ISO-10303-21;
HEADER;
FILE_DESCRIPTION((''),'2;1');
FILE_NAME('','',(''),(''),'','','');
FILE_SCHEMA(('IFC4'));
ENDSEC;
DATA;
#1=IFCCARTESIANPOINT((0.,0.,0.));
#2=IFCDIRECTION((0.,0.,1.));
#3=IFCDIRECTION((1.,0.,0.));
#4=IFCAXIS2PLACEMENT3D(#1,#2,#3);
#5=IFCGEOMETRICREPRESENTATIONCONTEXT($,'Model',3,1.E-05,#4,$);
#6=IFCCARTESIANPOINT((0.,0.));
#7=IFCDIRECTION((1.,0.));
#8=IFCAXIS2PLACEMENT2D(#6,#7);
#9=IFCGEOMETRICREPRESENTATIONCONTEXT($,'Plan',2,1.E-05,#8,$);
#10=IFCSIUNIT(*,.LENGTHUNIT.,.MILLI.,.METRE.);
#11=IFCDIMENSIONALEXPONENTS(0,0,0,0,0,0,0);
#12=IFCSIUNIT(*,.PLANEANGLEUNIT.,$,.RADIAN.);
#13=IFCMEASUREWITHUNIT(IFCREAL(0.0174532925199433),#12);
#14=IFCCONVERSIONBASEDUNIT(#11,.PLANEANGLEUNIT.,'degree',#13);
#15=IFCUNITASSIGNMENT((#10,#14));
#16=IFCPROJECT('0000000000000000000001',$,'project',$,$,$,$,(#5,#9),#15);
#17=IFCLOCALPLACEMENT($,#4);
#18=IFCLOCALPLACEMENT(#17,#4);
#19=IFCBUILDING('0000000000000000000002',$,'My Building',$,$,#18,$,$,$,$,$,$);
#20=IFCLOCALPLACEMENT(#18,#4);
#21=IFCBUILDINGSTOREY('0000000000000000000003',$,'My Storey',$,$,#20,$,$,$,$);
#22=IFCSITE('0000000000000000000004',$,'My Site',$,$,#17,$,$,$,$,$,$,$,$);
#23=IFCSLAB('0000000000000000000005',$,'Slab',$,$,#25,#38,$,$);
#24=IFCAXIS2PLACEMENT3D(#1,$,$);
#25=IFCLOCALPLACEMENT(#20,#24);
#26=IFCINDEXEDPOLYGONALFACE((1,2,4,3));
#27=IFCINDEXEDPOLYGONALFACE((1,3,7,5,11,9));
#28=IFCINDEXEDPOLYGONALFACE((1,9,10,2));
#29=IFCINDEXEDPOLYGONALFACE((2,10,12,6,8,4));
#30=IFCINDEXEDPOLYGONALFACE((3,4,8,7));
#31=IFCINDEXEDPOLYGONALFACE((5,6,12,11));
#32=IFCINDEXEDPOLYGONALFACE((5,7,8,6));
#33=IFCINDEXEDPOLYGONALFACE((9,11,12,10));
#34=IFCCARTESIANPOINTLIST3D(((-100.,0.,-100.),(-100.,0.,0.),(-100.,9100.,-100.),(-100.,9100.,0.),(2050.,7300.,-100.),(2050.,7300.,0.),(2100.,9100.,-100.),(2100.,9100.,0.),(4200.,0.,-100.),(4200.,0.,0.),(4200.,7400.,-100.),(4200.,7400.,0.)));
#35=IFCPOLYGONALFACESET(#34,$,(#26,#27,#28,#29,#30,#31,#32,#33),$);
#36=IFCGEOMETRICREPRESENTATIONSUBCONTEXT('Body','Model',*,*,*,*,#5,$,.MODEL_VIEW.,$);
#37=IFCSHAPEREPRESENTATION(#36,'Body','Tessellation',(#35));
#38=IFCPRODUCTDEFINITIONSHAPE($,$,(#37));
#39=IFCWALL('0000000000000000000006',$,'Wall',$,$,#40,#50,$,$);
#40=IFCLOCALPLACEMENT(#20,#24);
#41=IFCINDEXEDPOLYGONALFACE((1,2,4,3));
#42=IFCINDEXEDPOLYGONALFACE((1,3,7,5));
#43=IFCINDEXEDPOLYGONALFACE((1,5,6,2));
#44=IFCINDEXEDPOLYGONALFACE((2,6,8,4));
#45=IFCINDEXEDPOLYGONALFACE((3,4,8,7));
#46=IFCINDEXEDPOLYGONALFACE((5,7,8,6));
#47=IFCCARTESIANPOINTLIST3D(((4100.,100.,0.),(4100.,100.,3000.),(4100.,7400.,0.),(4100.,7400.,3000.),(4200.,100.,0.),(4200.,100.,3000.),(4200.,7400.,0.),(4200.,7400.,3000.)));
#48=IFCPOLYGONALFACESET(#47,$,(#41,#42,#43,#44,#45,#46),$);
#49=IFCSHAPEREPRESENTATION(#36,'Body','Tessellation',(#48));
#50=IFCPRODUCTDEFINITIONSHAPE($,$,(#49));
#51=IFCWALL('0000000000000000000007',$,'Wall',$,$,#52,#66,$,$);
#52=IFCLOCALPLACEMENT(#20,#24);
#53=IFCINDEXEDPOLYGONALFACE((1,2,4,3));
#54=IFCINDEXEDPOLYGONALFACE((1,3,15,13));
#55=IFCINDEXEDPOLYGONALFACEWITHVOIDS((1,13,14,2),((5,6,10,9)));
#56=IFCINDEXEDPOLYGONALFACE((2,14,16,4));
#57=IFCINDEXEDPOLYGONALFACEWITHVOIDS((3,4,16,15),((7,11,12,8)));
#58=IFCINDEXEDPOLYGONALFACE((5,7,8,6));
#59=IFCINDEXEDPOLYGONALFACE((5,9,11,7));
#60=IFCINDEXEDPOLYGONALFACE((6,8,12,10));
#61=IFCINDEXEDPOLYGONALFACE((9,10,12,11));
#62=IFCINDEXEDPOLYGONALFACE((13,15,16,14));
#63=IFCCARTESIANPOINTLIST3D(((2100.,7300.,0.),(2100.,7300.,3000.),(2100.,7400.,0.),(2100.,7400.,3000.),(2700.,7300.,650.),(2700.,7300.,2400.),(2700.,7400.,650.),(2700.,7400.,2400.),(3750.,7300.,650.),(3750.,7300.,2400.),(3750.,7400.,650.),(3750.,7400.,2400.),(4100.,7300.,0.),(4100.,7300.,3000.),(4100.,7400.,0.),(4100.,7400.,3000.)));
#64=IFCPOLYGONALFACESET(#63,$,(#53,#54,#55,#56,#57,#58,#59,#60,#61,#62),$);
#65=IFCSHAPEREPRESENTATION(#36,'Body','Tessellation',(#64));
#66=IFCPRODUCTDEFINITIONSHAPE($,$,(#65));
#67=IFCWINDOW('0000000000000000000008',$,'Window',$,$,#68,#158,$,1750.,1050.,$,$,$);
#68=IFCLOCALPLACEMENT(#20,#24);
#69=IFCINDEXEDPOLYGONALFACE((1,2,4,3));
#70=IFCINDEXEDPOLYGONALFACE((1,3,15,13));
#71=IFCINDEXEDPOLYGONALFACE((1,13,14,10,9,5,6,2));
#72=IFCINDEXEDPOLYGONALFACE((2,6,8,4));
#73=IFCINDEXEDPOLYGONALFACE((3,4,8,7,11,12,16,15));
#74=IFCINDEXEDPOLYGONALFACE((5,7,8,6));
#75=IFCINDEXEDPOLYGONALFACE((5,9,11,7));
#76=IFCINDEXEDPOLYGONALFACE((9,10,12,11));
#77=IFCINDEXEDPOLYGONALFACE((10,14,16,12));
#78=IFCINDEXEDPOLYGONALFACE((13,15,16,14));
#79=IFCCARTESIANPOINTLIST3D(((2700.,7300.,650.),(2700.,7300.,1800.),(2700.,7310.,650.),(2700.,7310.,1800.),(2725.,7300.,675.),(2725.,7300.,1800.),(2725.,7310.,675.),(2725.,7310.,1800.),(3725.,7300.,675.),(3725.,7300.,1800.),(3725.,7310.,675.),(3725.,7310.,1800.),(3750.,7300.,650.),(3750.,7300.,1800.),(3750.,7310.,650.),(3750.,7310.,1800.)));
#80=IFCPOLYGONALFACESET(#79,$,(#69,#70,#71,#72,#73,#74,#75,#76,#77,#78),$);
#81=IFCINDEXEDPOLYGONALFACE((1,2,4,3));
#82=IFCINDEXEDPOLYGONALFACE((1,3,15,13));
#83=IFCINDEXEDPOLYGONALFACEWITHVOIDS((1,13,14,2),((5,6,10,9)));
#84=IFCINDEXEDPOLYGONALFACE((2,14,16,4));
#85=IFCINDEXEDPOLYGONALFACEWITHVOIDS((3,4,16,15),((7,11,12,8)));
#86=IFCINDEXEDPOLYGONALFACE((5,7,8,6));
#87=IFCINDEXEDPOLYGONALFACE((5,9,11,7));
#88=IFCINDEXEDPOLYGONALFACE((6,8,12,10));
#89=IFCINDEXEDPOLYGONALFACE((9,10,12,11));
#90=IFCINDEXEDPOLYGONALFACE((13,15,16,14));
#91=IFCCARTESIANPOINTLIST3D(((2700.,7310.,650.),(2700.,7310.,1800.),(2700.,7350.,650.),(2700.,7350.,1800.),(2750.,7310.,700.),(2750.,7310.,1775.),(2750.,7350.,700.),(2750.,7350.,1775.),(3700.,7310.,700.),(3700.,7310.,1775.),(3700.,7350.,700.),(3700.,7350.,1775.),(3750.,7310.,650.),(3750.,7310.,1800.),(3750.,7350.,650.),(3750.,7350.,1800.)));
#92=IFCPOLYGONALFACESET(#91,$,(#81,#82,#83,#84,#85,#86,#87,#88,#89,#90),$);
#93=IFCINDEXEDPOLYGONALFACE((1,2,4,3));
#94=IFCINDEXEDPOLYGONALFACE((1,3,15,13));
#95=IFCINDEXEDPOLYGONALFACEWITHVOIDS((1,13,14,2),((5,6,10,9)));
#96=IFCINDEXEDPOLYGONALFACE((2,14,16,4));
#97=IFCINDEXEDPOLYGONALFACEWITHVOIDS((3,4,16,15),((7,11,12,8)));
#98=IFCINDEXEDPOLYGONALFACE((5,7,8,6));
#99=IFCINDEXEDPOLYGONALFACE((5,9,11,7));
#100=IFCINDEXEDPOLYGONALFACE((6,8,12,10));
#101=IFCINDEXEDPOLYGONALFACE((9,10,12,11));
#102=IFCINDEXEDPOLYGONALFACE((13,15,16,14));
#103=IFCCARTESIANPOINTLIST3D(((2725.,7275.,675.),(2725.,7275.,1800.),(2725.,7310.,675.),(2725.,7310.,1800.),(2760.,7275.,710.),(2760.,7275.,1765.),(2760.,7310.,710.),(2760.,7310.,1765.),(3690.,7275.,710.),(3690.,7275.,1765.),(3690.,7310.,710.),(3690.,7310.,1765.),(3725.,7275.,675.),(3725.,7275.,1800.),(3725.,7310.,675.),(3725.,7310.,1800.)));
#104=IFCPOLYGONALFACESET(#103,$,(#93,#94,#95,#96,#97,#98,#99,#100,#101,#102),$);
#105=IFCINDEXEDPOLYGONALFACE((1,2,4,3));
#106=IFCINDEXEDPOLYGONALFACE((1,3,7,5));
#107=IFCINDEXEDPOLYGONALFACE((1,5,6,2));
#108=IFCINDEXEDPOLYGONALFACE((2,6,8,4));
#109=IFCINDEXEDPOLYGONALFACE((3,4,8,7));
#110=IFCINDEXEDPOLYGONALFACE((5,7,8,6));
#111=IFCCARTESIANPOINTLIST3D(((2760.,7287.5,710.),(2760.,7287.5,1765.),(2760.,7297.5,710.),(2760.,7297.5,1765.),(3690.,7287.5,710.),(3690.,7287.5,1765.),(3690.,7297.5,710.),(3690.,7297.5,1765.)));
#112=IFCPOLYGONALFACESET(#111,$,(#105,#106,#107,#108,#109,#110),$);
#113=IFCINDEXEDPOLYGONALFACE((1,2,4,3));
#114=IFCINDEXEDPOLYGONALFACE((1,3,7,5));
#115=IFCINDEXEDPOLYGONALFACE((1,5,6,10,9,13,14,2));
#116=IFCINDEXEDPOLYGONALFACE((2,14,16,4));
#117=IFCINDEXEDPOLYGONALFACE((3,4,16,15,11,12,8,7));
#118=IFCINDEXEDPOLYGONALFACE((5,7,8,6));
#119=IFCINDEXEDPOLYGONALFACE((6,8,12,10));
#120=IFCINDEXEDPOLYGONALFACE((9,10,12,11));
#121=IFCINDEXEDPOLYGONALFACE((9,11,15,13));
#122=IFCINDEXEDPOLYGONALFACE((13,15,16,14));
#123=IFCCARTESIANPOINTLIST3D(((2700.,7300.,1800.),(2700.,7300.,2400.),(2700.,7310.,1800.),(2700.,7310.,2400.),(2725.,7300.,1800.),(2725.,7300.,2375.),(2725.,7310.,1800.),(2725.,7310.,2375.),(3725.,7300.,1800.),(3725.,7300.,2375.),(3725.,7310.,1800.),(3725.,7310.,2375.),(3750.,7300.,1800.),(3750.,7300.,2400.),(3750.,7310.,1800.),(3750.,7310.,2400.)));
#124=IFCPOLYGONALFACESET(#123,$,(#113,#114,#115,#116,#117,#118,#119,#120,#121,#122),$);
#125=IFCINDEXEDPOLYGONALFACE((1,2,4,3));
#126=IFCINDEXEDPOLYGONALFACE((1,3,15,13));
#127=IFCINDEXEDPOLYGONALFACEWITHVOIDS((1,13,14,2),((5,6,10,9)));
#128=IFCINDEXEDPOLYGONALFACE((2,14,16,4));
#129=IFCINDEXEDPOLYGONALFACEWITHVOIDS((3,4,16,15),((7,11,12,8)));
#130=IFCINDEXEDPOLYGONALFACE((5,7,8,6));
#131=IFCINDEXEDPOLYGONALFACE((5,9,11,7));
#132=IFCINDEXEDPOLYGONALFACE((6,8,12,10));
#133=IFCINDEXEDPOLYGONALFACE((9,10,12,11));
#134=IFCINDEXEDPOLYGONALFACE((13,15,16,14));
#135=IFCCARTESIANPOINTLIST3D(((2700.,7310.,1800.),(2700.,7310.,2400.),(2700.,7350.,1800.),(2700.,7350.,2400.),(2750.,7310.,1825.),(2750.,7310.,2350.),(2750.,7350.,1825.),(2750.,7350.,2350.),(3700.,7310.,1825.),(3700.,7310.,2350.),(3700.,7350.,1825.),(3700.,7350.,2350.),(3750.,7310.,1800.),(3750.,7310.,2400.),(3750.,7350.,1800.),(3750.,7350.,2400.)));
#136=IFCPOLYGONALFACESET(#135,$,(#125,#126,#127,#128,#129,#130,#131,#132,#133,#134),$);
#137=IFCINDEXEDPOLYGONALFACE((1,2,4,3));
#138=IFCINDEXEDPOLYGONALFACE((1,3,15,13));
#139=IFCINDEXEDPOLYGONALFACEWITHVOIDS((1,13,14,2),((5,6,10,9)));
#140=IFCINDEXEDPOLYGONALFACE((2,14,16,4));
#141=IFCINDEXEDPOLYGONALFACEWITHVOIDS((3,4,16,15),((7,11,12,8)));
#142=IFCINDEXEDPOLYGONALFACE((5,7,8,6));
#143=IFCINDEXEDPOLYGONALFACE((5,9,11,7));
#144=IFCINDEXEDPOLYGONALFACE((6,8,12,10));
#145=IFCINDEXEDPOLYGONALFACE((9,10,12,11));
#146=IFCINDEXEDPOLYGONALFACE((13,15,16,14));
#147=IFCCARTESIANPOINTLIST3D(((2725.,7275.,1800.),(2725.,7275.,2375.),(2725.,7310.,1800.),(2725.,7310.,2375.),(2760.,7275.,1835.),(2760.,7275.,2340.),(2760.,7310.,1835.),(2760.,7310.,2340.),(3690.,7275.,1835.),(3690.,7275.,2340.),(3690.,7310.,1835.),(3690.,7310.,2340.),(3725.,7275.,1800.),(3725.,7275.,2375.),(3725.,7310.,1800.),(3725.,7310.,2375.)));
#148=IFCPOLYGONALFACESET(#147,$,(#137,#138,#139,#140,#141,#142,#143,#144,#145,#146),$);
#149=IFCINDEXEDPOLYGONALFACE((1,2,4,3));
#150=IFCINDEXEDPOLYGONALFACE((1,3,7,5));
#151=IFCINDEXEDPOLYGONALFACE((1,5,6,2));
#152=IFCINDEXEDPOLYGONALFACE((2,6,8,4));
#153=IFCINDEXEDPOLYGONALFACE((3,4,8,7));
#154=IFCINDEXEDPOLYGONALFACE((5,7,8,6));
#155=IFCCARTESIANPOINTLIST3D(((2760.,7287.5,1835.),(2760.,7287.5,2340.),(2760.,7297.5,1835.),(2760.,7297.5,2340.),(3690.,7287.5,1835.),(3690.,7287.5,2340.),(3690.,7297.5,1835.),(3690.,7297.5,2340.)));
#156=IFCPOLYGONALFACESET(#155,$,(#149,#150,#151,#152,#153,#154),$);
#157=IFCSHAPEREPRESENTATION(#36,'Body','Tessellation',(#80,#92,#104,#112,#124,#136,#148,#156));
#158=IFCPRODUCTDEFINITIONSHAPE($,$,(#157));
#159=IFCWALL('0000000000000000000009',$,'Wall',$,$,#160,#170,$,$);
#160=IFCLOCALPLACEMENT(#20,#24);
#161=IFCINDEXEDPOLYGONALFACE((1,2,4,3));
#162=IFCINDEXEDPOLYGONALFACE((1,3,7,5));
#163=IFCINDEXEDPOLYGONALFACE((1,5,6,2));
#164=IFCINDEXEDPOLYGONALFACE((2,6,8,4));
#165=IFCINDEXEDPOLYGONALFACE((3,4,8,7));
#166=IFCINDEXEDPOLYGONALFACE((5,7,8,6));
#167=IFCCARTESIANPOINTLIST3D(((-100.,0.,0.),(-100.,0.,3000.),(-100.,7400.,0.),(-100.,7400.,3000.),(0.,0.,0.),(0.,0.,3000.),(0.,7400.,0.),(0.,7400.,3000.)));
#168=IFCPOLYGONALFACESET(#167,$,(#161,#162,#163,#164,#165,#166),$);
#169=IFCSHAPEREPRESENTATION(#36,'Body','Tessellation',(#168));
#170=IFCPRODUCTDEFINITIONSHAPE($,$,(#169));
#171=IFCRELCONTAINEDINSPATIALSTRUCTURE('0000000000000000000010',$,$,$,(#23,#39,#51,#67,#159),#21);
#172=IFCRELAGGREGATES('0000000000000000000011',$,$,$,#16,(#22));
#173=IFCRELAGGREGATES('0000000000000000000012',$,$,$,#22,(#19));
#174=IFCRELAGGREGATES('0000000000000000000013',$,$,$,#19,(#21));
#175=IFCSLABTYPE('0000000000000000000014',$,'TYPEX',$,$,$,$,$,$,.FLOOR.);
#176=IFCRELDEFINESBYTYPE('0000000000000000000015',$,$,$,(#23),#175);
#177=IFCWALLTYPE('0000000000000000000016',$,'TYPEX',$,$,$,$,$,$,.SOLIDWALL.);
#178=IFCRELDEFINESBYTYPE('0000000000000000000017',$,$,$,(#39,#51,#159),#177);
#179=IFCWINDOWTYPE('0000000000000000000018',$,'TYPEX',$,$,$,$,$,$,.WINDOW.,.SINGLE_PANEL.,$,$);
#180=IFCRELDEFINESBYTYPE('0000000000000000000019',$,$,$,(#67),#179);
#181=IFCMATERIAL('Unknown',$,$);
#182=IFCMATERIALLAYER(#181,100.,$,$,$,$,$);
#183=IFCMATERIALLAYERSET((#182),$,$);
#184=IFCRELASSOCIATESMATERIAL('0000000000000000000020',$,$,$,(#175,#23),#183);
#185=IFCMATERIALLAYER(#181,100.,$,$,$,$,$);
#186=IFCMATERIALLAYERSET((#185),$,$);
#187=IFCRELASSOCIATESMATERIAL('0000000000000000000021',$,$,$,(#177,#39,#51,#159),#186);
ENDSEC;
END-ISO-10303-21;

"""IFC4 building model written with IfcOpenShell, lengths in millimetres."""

from ifc_helpers import new_model, entity, si_unit, converted_unit, frame, origin_with_axes, origin_2d_with_axis, place, context, subcontext, project, spatial, line, indexed_curve, outline, extrude, shape, source, transform, mapped, material, layer, layer_set, layer_usage, type_object, type_shapes, element, fill, save


model = new_model("IFC4")

# Units and contexts
model_context = context("Model", 3, precision=1e-05, world=origin_with_axes())
plan_context = context("Plan", 2, precision=1e-05, world=origin_2d_with_axis())
body_context_1 = subcontext(model_context, "Body", "Model", "MODEL_VIEW")
body_context_2 = subcontext(plan_context, "Body", "Plan", "PLAN_VIEW")
ifc_project = project(units=[si_unit("LENGTHUNIT", "METRE", prefix="MILLI"), converted_unit("PLANEANGLEUNIT", "degree", entity("IfcReal", 0.0174532925199433), si_unit("PLANEANGLEUNIT", "RADIAN"), dimensions=[0, 0, 0, 0, 0, 0, 0])], contexts=[model_context, plan_context])

# Site, building, storey
site_placement = place(None, origin_with_axes())
site = spatial("IfcSite", under=ifc_project, at=site_placement, Name="My Site")
building_placement = place(site_placement, origin_with_axes())
building = spatial("IfcBuilding", under=site, at=building_placement, Name="My Building")
storey_placement = place(building_placement, origin_with_axes())
storey = spatial("IfcBuildingStorey", under=building, at=storey_placement, Name="My Storey")

# Slab
ifc_material = material(Name="Unknown")
ifc_layer_1 = layer(ifc_material, 100.0)
ifc_layer_set_1 = layer_set([ifc_layer_1])
ifc_layer_usage_1 = layer_usage(ifc_layer_set_1, "AXIS3", "POSITIVE", 0.0)
slab_type = type_object("IfcSlabType", Name="TYPEX", PredefinedType="FLOOR", material=ifc_layer_set_1)
slab_placement = place(storey_placement, frame((-100.0, 0.0, -100.0), z_axis=(0.0, 0.0, 1.0), x_axis=(1.0, 0.0, 0.0)))
element("IfcSlab", 1, at=slab_placement, inside=storey, type_object=slab_type, material=ifc_layer_usage_1, Name="Slab", context=body_context_1, shape_type="SweptSolid", body=[
    extrude(outline(indexed_curve([(0.0, 0.0), (4300.0, 0.0), (4300.0, 7400.0), (0.0, 9100.0), (2150.0, 7300.0), (2200.0, 9100.0)], segments=[line(2, 3), line(3, 5), line(5, 6), line(6, 4), line(4, 1), line(1, 2)], self_intersect=False)), None, (0.0, 0.0, 1.0), 100.0),
])

# Shared definitions
ifc_layer_2 = layer(ifc_material, 100.0)
ifc_layer_set_2 = layer_set([ifc_layer_2])
wall_type = type_object("IfcWallType", Name="TYPEX", PredefinedType="SOLIDWALL", material=ifc_layer_set_2)
shared_shape_1 = source(origin_with_axes(), body_context_1, "Body", "SweptSolid", [
    extrude(outline(indexed_curve([(0.0, 0.0), (1050.0, 0.0), (1050.0, 1750.0), (0.0, 1750.0)], segments=[line(1, 2, 3, 4, 1)])), frame((0.0, -100.0, 0.0), z_axis=(0.0, -1.0, 0.0), x_axis=(1.0, 0.0, 0.0)), (0.0, 0.0, -1.0), 300.0),
])
window_type = type_object("IfcWindowType", Name="TYPEX", PartitioningType="SINGLE_PANEL", PredefinedType="WINDOW")
shared_shape_2 = source(origin_with_axes(), body_context_1, "Body", "SweptSolid", [
    extrude(outline(indexed_curve([(1050.0, 1150.0), (1050.0, 0.0), (0.0, 0.0), (0.0, 1150.0), (25.0, 1150.0), (25.0, 25.0), (1025.0, 25.0), (1025.0, 1150.0)], segments=[line(1, 2, 3, 4, 5, 6, 7, 8, 1)])), frame((0.0, 90.0, 0.0), z_axis=(0.0, -1.0, 0.0), x_axis=(1.0, 0.0, 0.0)), (0.0, 0.0, -1.0), 10.0),
    extrude(outline(indexed_curve([(0.0, 0.0), (1050.0, 0.0), (1050.0, 1150.0), (0.0, 1150.0)], segments=[line(1, 2, 3, 4, 1)]), holes=[indexed_curve([(50.0, 50.0), (1000.0, 50.0), (1000.0, 1125.0), (50.0, 1125.0)], segments=[line(1, 2, 3, 4, 1)])]), frame((0.0, 50.0, 0.0), z_axis=(0.0, -1.0, 0.0), x_axis=(1.0, 0.0, 0.0)), (0.0, 0.0, -1.0), 40.0),
    extrude(outline(indexed_curve([(0.0, 0.0), (1000.0, 0.0), (1000.0, 1125.0), (0.0, 1125.0)], segments=[line(1, 2, 3, 4, 1)]), holes=[indexed_curve([(35.0, 35.0), (965.0, 35.0), (965.0, 1090.0), (35.0, 1090.0)], segments=[line(1, 2, 3, 4, 1)])]), frame((25.0, 90.0, 25.0), z_axis=(0.0, -1.0, 0.0), x_axis=(1.0, 0.0, 0.0)), (0.0, 0.0, -1.0), 35.0),
    extrude(outline(indexed_curve([(35.0, 35.0), (965.0, 35.0), (965.0, 1090.0), (35.0, 1090.0)], segments=[line(1, 2, 3, 4, 1)])), frame((25.0, 102.5, 25.0), z_axis=(0.0, -1.0, 0.0), x_axis=(1.0, 0.0, 0.0)), (0.0, 0.0, -1.0), 10.0),
    extrude(outline(indexed_curve([(0.0, 0.0), (0.0, 600.0), (1050.0, 600.0), (1050.0, 0.0), (1025.0, 0.0), (1025.0, 575.0), (25.0, 575.0), (25.0, 0.0)], segments=[line(1, 2, 3, 4, 5, 6, 7, 8, 1)])), frame((0.0, 90.0, 1150.0), z_axis=(0.0, -1.0, 0.0), x_axis=(1.0, 0.0, 0.0)), (0.0, 0.0, -1.0), 10.0),
    extrude(outline(indexed_curve([(0.0, 0.0), (1050.0, 0.0), (1050.0, 600.0), (0.0, 600.0)], segments=[line(1, 2, 3, 4, 1)]), holes=[indexed_curve([(50.0, 25.0), (1000.0, 25.0), (1000.0, 550.0), (50.0, 550.0)], segments=[line(1, 2, 3, 4, 1)])]), frame((0.0, 50.0, 1150.0), z_axis=(0.0, -1.0, 0.0), x_axis=(1.0, 0.0, 0.0)), (0.0, 0.0, -1.0), 40.0),
    extrude(outline(indexed_curve([(0.0, 0.0), (1000.0, 0.0), (1000.0, 575.0), (0.0, 575.0)], segments=[line(1, 2, 3, 4, 1)]), holes=[indexed_curve([(35.0, 35.0), (965.0, 35.0), (965.0, 540.0), (35.0, 540.0)], segments=[line(1, 2, 3, 4, 1)])]), frame((25.0, 90.0, 1150.0), z_axis=(0.0, -1.0, 0.0), x_axis=(1.0, 0.0, 0.0)), (0.0, 0.0, -1.0), 35.0),
    extrude(outline(indexed_curve([(35.0, 35.0), (965.0, 35.0), (965.0, 540.0), (35.0, 540.0)], segments=[line(1, 2, 3, 4, 1)])), frame((25.0, 102.5, 1150.0), z_axis=(0.0, -1.0, 0.0), x_axis=(1.0, 0.0, 0.0)), (0.0, 0.0, -1.0), 10.0),
])
shared_shape_3 = source(origin_with_axes(), body_context_2, "Body", "Curve2D", [
    entity("IfcIndexedPolyCurve", entity("IfcCartesianPointList2D", [[50.0, 50.0], [1000.0, 50.0]])),
    entity("IfcIndexedPolyCurve", entity("IfcCartesianPointList2D", [[0.0, 100.0], [25.0, 100.0], [25.0, 90.0], [50.0, 90.0], [50.0, 50.0], [0.0, 50.0]]), [entity("IfcLineIndex", [1, 2, 3, 4, 5, 6, 1])]),
    entity("IfcIndexedPolyCurve", entity("IfcCartesianPointList2D", [[1050.0, 100.0], [1025.0, 100.0], [1025.0, 90.0], [1000.0, 90.0], [1000.0, 50.0], [1050.0, 50.0]]), [entity("IfcLineIndex", [1, 2, 3, 4, 5, 6, 1])]),
    entity("IfcIndexedPolyCurve", entity("IfcCartesianPointList2D", [[25.0, 90.0], [60.0, 90.0], [60.0, 125.0], [25.0, 125.0]]), [entity("IfcLineIndex", [1, 2, 3, 4, 1])]),
    entity("IfcIndexedPolyCurve", entity("IfcCartesianPointList2D", [[1025.0, 90.0], [990.0, 90.0], [990.0, 125.0], [1025.0, 125.0]]), [entity("IfcLineIndex", [1, 2, 3, 4, 1])]),
    entity("IfcIndexedPolyCurve", entity("IfcCartesianPointList2D", [[60.0, 90.0], [990.0, 90.0]])),
    entity("IfcIndexedPolyCurve", entity("IfcCartesianPointList2D", [[60.0, 125.0], [990.0, 125.0]])),
    entity("IfcIndexedPolyCurve", entity("IfcCartesianPointList2D", [[60.0, 107.5], [990.0, 107.5]])),
])
type_shapes(window_type, [shared_shape_2, shared_shape_3])

# Wall
ifc_layer_usage_2 = layer_usage(ifc_layer_set_2, "AXIS2", "POSITIVE", 0.0)
wall_1_placement = place(storey_placement, frame((4200.0, 100.0, 0.0), z_axis=(0.0, 0.0, 1.0), x_axis=(0.0, 1.0, 0.0)))
element("IfcWall", 2, at=wall_1_placement, inside=storey, type_object=wall_type, material=ifc_layer_usage_2, Name="Wall", context=body_context_1, shape_type="SweptSolid", body=[
    extrude(outline(indexed_curve([(0.0, 0.0), (0.0, 100.0), (7300.0, 100.0), (7300.0, 0.0), (0.0, 0.0)], self_intersect=False)), origin_with_axes(), (0.0, 0.0, 1.0), 3000.0),
])

# Wall, opening, window
ifc_layer_usage_3 = layer_usage(ifc_layer_set_2, "AXIS2", "POSITIVE", 0.0)
wall_2_placement = place(storey_placement, frame((4100.0, 7400.0, 0.0), z_axis=(0.0, 0.0, 1.0), x_axis=(-1.0, 0.0, 0.0)))
wall_2 = element("IfcWall", 3, at=wall_2_placement, inside=storey, type_object=wall_type, material=ifc_layer_usage_3, Name="Wall", context=body_context_1, shape_type="SweptSolid", body=[
    extrude(outline(indexed_curve([(0.0, 0.0), (0.0, 100.0), (2000.0, 100.0), (2000.0, 0.0), (0.0, 0.0)], self_intersect=False)), origin_with_axes(), (0.0, 0.0, 1.0), 3000.0),
])
opening_1_placement = place(wall_2_placement, frame((350.0, 0.0, 650.0), z_axis=(0.0, 0.0, 1.0), x_axis=(1.0, 0.0, 0.0)))
opening_1 = element("IfcOpeningElement", 4, at=opening_1_placement, cuts=wall_2, PredefinedType="OPENING", context=body_context_1, shape_type="MappedRepresentation", body=[
    mapped(shared_shape_1, transform((0.0, 0.0, 0.0), x_axis=(1.0, 0.0, 0.0), y_axis=(0.0, 1.0, 0.0), z_axis=(0.0, 0.0, 1.0), scale=1.0)),
])
window_1_placement = place(opening_1_placement, frame((0.0, 0.0, 0.0), z_axis=(0.0, 0.0, 1.0), x_axis=(1.0, 0.0, 0.0)))
window_1 = element("IfcWindow", 5, at=window_1_placement, inside=storey, type_object=window_type, Name="Window", OverallHeight=1750.0, OverallWidth=1050.0, shapes=[
    shape(body_context_1, "Body", "MappedRepresentation", [mapped(shared_shape_2, transform((0.0, 0.0, 0.0), x_axis=(1.0, 0.0, 0.0), y_axis=(0.0, 1.0, 0.0), z_axis=(0.0, 0.0, 1.0), scale=1.0))]),
    shape(body_context_2, "Body", "MappedRepresentation", [mapped(shared_shape_3, transform((0.0, 0.0, 0.0), x_axis=(1.0, 0.0, 0.0), y_axis=(0.0, 1.0, 0.0), z_axis=(0.0, 0.0, 1.0), scale=1.0))]),
])
fill(opening_1, window_1)

# Wall
ifc_layer_usage_4 = layer_usage(ifc_layer_set_2, "AXIS2", "POSITIVE", 0.0)
wall_3_placement = place(storey_placement, frame((0.0, 0.0, 0.0), z_axis=(0.0, 0.0, 1.0), x_axis=(0.000001, 1.0, 0.0)))
element("IfcWall", 6, at=wall_3_placement, inside=storey, type_object=wall_type, material=ifc_layer_usage_4, Name="Wall", context=body_context_1, shape_type="SweptSolid", body=[
    extrude(outline(indexed_curve([(0.0, 0.0), (0.0, 100.0), (7400.0, 100.0), (7400.0, 0.0), (0.0, 0.0)], self_intersect=False)), origin_with_axes(), (0.0, 0.0, 1.0), 3000.0),
])

save(model, "model.ifc")
